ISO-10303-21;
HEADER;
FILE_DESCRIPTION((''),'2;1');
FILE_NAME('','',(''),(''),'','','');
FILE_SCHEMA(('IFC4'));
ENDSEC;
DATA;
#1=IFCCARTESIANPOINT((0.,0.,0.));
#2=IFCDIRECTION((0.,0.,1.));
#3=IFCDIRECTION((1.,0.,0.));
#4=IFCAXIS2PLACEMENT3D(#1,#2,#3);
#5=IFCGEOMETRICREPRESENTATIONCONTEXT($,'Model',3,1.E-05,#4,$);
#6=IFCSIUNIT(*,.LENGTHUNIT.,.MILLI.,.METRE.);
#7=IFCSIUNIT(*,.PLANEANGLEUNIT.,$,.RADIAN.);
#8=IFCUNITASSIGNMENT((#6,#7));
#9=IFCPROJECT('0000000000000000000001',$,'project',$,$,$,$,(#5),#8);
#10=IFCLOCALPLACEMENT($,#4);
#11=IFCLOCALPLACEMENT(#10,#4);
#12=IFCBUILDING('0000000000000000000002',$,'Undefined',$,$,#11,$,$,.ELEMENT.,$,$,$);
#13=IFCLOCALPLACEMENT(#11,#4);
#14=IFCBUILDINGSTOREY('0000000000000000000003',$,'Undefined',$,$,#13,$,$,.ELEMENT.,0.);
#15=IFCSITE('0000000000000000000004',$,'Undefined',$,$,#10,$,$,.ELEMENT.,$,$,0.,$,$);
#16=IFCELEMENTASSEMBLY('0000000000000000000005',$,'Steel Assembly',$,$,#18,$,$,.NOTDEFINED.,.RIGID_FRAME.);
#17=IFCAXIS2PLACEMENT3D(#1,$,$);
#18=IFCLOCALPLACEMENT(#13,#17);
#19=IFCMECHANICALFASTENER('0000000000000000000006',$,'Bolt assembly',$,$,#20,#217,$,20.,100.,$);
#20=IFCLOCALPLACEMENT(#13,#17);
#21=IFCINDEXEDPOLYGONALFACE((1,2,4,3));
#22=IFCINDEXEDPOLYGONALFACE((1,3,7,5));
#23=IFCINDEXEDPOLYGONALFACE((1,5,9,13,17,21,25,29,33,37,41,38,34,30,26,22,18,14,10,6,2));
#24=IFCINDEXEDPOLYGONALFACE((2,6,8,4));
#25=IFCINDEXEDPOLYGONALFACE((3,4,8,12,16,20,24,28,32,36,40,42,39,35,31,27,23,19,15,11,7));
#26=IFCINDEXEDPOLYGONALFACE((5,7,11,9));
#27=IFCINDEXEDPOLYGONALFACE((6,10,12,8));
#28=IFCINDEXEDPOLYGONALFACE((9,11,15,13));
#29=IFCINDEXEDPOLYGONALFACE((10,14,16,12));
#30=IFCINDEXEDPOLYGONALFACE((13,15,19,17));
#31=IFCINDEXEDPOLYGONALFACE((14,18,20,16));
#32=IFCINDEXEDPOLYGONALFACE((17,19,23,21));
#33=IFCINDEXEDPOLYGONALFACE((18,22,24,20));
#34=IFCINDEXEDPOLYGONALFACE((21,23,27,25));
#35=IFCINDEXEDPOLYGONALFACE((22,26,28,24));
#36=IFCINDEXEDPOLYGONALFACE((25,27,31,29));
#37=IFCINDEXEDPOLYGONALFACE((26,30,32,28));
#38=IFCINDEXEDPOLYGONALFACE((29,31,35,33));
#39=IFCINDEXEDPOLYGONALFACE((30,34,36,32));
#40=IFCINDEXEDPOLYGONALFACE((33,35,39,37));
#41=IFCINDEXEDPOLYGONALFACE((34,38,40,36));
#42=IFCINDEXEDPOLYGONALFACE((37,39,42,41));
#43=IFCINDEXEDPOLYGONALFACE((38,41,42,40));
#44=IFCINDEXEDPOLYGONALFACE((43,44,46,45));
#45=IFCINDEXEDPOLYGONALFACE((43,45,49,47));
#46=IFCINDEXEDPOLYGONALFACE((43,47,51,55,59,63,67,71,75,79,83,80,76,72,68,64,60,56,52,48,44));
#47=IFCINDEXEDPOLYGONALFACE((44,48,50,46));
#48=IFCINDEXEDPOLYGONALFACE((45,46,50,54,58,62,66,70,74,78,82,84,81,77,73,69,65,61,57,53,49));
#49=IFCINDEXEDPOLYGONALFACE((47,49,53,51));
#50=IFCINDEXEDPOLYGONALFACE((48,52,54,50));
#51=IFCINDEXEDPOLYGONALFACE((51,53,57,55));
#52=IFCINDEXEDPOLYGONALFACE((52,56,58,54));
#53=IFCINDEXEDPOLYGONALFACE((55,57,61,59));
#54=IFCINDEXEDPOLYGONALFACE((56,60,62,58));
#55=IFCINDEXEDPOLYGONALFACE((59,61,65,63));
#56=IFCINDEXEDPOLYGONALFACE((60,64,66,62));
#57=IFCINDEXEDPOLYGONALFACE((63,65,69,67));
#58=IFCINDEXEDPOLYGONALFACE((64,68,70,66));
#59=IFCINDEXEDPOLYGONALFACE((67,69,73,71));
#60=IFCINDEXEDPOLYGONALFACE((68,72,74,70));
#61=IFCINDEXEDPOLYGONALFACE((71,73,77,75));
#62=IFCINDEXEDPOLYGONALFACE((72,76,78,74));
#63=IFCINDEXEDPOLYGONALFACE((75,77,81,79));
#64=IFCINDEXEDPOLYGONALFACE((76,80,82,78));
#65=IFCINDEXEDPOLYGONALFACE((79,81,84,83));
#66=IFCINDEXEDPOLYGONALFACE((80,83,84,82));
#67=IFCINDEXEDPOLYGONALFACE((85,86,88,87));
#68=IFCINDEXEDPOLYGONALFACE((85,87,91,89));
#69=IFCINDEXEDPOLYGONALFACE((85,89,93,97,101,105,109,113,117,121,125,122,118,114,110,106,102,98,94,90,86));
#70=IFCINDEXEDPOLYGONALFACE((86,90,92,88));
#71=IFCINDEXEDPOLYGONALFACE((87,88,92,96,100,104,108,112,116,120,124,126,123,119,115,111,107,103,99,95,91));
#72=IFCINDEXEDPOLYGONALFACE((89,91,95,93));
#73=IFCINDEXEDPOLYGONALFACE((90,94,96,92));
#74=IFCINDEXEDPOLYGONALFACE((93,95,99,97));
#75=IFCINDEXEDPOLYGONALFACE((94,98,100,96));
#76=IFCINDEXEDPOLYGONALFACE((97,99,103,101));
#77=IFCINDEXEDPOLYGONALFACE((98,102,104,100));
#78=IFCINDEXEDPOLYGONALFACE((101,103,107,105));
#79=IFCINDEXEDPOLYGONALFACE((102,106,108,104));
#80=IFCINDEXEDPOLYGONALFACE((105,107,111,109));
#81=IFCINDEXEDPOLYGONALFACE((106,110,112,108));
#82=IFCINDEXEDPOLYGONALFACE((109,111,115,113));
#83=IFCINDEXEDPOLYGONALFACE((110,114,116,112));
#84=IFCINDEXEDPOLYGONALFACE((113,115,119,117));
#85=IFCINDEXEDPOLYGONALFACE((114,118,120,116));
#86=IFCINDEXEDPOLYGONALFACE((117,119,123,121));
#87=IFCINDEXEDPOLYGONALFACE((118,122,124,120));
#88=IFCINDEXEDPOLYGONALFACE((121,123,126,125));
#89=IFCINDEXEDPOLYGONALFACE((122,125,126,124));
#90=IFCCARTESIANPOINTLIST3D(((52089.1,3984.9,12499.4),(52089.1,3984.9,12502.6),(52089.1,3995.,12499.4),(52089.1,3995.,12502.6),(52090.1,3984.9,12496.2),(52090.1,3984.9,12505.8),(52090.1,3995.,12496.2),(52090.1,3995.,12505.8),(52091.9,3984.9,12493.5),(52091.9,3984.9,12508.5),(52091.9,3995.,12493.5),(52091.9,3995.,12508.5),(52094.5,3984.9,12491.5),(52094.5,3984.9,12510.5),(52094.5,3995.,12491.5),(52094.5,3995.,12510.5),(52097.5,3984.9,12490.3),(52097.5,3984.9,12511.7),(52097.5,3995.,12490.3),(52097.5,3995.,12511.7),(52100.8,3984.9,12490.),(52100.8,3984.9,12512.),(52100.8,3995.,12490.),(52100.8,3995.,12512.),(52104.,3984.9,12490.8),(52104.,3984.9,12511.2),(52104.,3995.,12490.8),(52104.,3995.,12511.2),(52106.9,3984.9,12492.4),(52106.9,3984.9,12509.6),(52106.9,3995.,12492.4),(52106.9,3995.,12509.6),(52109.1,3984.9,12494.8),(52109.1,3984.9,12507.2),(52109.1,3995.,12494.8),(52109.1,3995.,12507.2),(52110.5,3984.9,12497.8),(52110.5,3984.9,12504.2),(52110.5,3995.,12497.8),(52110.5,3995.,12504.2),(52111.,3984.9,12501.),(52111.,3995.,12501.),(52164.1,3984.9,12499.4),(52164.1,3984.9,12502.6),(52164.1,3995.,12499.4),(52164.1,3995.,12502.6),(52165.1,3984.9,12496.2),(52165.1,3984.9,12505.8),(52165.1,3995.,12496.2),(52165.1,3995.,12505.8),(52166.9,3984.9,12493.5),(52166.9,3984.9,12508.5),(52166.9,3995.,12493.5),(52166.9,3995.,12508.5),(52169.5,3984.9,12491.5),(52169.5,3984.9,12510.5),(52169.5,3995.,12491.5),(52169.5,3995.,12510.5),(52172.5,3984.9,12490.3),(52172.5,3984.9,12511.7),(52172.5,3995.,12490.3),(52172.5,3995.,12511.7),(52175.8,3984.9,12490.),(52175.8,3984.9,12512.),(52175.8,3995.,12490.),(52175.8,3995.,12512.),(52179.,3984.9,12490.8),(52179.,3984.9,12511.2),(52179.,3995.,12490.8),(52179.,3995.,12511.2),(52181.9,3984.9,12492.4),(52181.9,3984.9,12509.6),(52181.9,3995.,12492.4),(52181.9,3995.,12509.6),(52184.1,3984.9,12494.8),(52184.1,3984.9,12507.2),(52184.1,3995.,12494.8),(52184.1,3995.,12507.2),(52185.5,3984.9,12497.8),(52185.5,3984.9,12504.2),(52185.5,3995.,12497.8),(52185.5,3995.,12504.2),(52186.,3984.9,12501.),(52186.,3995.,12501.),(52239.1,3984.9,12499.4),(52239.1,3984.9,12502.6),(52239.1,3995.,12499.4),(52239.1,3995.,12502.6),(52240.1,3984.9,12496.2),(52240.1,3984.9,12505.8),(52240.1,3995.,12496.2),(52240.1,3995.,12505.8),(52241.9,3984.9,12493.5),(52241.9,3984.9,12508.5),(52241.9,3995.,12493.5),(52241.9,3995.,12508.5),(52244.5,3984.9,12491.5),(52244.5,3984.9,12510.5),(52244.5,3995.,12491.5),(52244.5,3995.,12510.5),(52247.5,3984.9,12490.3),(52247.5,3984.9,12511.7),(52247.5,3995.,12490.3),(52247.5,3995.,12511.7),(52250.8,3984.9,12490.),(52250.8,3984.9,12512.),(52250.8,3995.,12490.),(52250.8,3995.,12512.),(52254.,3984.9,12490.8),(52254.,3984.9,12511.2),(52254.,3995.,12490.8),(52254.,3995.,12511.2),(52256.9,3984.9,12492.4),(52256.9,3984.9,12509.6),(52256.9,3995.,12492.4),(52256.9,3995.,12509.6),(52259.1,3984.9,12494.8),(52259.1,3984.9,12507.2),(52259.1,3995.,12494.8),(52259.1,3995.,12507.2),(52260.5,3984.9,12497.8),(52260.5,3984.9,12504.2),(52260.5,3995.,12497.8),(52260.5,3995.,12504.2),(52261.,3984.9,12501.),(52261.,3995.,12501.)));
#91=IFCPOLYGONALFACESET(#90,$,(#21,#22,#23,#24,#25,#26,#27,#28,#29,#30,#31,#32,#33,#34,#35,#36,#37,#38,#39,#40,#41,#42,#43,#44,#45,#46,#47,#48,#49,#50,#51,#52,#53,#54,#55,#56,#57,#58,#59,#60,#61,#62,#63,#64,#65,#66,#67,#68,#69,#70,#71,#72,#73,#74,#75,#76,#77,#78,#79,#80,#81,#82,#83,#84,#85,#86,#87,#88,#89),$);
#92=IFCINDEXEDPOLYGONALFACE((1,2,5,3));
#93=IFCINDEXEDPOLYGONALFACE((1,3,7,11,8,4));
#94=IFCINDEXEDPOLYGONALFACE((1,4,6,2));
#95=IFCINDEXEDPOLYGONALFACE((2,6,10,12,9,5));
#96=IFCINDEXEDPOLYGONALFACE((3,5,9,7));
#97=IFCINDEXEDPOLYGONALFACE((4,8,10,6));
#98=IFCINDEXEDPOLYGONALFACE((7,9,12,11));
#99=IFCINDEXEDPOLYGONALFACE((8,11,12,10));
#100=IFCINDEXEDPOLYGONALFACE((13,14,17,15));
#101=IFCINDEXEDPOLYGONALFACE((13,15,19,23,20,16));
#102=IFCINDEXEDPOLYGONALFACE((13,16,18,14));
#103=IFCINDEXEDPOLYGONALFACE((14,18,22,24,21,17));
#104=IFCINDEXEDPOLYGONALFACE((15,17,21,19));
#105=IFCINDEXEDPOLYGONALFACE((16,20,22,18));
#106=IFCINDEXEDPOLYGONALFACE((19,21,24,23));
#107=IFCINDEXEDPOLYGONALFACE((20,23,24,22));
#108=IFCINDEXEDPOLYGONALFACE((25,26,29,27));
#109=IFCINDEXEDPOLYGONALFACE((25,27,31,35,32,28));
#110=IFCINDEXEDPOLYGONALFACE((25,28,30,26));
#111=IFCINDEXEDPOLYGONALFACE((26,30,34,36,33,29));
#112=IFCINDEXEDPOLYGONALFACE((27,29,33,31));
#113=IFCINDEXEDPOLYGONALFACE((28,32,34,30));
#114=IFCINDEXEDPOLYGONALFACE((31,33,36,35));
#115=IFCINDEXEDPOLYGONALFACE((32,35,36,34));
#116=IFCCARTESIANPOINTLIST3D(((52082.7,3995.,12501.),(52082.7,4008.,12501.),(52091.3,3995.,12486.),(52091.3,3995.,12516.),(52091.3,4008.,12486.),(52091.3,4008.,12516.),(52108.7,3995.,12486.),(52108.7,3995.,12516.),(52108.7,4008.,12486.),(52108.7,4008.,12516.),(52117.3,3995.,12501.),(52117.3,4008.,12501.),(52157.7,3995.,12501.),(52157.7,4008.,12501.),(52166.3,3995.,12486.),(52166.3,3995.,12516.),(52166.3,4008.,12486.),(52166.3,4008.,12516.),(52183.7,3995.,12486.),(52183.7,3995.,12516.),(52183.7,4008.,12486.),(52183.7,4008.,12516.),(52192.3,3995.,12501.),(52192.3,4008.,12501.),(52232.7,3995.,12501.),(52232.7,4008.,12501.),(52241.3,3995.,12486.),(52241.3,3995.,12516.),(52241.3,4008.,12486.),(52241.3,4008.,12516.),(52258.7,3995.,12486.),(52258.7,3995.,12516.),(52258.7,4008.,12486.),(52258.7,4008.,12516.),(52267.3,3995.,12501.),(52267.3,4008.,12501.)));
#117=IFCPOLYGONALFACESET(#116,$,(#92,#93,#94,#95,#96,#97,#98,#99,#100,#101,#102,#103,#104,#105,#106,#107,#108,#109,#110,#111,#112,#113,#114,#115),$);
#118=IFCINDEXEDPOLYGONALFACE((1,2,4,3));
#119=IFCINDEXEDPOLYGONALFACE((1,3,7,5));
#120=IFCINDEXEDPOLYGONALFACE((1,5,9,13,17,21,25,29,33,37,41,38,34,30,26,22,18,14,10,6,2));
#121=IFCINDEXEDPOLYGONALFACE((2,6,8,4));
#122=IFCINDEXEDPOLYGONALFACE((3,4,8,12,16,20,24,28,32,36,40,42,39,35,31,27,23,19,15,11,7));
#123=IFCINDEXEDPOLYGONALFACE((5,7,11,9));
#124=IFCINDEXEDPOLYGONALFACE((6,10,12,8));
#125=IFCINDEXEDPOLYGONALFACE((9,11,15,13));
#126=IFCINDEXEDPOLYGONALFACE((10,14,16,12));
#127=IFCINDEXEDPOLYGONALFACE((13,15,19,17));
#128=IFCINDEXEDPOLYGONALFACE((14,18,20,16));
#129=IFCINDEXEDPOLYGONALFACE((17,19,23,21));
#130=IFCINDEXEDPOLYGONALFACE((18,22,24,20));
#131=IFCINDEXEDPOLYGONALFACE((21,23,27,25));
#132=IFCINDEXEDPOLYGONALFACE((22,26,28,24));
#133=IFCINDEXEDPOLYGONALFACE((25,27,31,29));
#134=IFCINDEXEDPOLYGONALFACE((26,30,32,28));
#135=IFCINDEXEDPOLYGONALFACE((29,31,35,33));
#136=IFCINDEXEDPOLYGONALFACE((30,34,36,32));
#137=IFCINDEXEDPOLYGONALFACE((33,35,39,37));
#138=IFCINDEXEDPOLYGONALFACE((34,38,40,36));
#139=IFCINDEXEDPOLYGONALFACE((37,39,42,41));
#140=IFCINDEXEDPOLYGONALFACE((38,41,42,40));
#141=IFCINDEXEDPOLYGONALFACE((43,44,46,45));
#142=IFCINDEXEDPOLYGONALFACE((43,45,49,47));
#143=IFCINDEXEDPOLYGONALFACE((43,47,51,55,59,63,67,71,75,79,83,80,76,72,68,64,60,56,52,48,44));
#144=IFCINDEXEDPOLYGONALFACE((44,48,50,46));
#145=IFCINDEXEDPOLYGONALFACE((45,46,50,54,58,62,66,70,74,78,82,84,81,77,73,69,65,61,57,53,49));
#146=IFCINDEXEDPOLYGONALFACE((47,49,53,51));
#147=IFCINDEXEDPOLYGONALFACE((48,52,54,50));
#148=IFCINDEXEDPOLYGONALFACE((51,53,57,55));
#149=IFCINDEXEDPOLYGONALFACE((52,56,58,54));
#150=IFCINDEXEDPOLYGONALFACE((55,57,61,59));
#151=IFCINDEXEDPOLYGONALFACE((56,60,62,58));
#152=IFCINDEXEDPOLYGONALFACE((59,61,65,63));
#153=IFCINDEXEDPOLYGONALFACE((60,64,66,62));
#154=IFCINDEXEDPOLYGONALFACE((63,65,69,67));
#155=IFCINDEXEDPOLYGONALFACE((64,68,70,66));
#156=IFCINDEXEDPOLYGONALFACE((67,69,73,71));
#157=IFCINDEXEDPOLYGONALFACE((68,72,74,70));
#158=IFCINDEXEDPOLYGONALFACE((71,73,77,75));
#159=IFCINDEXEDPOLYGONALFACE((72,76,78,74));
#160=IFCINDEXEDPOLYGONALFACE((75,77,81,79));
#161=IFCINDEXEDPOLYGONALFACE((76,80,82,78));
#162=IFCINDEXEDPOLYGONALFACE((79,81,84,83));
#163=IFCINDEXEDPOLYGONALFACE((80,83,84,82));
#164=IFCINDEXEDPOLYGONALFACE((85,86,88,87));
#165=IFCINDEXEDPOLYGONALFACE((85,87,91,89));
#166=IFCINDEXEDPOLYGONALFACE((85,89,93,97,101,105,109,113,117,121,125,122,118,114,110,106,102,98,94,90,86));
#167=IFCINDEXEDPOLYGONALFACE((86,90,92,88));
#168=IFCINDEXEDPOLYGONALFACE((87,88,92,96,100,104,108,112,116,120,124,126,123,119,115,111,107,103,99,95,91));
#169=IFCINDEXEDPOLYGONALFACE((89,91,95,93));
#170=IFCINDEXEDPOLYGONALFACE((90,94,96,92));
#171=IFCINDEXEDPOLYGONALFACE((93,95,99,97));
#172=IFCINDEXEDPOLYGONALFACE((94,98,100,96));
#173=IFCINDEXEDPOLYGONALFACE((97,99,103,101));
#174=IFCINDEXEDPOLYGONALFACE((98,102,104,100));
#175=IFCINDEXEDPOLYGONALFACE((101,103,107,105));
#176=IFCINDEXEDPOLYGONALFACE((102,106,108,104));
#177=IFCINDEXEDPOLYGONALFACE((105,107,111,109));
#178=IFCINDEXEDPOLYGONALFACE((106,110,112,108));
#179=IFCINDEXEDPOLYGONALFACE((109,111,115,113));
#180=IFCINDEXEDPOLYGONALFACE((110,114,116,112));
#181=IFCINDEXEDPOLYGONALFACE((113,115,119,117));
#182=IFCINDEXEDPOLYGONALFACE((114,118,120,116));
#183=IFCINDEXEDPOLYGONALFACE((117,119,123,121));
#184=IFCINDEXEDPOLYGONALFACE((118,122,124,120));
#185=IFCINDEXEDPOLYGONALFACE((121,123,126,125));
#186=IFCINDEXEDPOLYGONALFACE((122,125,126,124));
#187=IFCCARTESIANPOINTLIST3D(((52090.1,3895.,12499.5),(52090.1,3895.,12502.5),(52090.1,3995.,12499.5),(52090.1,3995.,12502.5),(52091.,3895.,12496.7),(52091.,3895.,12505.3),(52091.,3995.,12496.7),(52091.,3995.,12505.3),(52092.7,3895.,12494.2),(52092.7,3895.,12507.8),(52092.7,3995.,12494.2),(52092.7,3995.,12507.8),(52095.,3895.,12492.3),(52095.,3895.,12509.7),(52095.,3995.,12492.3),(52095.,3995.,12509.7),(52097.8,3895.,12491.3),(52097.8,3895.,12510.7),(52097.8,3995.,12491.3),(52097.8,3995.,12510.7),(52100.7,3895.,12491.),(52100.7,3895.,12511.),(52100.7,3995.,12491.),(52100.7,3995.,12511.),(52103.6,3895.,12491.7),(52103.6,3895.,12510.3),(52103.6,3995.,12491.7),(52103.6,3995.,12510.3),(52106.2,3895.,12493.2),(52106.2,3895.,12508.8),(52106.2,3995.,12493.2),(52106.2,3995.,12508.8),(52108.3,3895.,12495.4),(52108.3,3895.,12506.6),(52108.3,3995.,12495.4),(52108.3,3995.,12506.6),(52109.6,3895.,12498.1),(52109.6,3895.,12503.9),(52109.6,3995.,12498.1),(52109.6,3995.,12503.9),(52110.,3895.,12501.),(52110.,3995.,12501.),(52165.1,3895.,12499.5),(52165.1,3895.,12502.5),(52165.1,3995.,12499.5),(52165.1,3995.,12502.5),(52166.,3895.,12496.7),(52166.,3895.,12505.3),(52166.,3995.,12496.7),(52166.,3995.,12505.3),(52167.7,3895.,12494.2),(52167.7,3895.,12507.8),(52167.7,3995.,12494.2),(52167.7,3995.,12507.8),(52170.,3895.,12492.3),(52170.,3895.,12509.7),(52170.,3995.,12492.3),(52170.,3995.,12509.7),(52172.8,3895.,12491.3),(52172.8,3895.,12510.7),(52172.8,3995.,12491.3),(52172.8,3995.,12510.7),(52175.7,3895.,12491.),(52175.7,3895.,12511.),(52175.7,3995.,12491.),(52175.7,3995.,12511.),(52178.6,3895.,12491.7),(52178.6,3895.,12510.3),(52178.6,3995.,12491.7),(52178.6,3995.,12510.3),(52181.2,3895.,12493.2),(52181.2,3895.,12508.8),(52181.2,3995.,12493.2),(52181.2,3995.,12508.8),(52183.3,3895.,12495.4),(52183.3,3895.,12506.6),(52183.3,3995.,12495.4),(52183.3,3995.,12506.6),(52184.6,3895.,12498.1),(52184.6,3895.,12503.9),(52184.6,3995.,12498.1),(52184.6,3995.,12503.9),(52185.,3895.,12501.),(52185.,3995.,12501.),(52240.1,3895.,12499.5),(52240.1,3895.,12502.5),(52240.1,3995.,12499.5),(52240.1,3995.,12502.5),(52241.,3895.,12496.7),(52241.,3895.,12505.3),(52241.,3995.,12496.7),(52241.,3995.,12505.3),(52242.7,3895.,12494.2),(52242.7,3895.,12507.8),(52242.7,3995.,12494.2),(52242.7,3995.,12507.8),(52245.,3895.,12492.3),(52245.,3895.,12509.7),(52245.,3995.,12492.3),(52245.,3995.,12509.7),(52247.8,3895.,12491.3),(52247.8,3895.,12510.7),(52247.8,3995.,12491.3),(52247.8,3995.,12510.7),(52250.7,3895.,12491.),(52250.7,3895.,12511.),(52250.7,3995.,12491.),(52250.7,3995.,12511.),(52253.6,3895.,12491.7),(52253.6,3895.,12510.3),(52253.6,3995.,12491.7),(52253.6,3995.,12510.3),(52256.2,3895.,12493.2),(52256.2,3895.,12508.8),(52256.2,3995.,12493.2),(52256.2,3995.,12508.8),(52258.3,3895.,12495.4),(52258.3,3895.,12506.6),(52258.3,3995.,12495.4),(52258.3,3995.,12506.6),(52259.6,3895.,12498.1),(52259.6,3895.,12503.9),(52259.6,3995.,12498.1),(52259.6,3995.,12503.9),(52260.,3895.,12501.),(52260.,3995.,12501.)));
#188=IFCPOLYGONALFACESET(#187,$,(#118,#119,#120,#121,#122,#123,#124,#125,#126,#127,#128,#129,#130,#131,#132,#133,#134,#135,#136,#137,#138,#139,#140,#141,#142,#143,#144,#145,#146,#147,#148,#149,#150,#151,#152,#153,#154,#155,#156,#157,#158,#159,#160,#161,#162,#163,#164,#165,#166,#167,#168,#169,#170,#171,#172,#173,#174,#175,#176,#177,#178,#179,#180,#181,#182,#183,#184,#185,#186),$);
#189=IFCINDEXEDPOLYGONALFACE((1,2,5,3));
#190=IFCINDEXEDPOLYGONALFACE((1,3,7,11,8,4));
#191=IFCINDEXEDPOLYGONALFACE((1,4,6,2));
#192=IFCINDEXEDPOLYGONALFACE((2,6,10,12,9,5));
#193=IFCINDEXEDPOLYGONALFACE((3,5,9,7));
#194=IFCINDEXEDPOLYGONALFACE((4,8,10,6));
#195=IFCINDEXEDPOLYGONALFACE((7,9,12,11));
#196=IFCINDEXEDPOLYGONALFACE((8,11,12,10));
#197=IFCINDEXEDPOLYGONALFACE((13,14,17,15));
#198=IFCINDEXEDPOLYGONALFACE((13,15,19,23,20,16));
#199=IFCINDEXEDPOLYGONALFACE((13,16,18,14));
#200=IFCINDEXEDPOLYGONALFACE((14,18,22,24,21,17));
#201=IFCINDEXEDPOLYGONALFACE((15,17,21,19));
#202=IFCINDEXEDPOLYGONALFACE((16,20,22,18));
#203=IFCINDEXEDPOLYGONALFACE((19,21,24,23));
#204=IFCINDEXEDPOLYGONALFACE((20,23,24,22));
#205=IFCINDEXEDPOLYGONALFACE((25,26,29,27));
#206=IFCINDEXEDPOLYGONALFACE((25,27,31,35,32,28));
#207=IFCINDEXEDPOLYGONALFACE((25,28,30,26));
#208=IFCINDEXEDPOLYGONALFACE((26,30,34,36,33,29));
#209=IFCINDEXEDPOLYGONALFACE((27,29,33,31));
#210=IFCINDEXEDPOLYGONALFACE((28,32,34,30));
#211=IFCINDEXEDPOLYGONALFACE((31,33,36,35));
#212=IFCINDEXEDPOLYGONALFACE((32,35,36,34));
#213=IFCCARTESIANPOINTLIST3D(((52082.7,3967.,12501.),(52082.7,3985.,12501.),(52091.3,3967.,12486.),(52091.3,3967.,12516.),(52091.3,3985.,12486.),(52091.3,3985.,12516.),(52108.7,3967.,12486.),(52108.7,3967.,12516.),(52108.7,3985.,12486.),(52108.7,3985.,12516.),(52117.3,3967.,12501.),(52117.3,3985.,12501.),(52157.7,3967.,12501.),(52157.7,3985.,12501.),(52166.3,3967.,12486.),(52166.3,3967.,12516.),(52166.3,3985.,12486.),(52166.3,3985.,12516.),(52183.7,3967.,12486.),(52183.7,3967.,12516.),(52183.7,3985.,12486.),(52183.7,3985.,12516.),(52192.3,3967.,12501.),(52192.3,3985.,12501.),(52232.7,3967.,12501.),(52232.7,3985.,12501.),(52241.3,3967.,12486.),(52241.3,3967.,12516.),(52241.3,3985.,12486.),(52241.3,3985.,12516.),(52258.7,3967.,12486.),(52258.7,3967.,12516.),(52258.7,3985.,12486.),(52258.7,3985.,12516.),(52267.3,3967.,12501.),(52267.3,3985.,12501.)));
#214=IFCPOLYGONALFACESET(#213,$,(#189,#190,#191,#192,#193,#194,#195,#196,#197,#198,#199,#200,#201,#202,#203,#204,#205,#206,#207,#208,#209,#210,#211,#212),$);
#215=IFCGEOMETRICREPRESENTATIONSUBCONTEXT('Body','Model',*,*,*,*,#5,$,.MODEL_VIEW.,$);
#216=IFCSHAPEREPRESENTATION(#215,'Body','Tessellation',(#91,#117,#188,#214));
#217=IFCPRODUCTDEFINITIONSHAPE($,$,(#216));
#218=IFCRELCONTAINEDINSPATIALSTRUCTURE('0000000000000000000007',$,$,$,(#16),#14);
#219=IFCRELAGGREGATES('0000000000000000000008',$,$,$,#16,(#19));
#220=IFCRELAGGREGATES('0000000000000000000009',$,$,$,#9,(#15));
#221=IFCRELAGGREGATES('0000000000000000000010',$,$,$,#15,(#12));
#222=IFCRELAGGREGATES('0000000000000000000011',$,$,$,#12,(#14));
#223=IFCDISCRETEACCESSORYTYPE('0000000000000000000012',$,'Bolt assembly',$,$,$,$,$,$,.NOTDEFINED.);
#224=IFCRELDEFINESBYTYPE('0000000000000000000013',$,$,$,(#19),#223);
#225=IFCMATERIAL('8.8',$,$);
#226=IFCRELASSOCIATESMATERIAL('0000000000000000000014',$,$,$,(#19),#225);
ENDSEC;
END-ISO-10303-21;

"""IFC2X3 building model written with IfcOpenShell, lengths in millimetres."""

from ifc_helpers import new_model, si_unit, frame, origin_with_axes, origin_2d_with_axis, place, context, subcontext, project, spatial, polyline, circle, outline, extrude, source, transform, mapped, material, type_object, element, aggregate, save


model = new_model("IFC2X3")

# Units and contexts
model_context = context("Model", 3, precision=1e-05, world=origin_with_axes())
body_context = subcontext(model_context, "Body", "Model", "MODEL_VIEW")
ifc_project = project(units=[si_unit("LENGTHUNIT", "METRE", prefix="MILLI"), si_unit("PLANEANGLEUNIT", "RADIAN")], contexts=[model_context])

# Site, building, storey
site_placement = place(None, origin_with_axes())
site = spatial("IfcSite", under=ifc_project, at=site_placement, Name="Undefined", CompositionType="ELEMENT", RefElevation=0.0)
building_placement = place(site_placement, origin_with_axes())
building = spatial("IfcBuilding", under=site, at=building_placement, Name="Undefined", CompositionType="ELEMENT")
storey_placement = place(building_placement, origin_with_axes())
storey = spatial("IfcBuildingStorey", under=building, at=storey_placement, Name="Undefined", CompositionType="ELEMENT", Elevation=0.0)

# Element assembly
assembly_1_placement = place(storey_placement, origin_with_axes())
assembly_1 = element("IfcElementAssembly", 1, at=assembly_1_placement, inside=storey, Name="Steel Assembly", AssemblyPlace="NOTDEFINED", PredefinedType="RIGID_FRAME")

# Shared definitions
ifc_material_1 = material(Name="8.8")
discrete_accessory_type_1 = type_object("IfcDiscreteAccessoryType", Name="Bolt assembly")

# Mechanical fastener
shared_shape_1 = source(origin_with_axes(), body_context, "Body", "SweptSolid", [
    extrude(circle(Radius=11.0, at=origin_2d_with_axis()), frame((0.0, 5.0, 0.0), z_axis=(0.0, 1.0, 0.0), x_axis=(1.0, 0.0, 0.0)), (0.0, 0.0, 1.0), 10.1),
    extrude(outline(polyline([(17.3, 0.0), (8.7, 15.0), (-8.7, 15.0), (-17.3, 0.0), (-8.7, -15.0), (8.7, -15.0), (17.3, 0.0)])), frame((0.0, -8.0, 0.0), z_axis=(0.0, 1.0, 0.0), x_axis=(1.0, 0.0, 0.0)), (0.0, 0.0, 1.0), 13.0),
    extrude(circle(Radius=10.0, at=origin_2d_with_axis()), frame((0.0, 5.0, 0.0), z_axis=(0.0, 1.0, 0.0), x_axis=(1.0, 0.0, 0.0)), (0.0, 0.0, 1.0), 100.0),
    extrude(outline(polyline([(17.3, 0.0), (8.7, 15.0), (-8.7, 15.0), (-17.3, 0.0), (-8.7, -15.0), (8.7, -15.0), (17.3, 0.0)])), frame((0.0, 15.0, 0.0), z_axis=(0.0, 1.0, 0.0), x_axis=(1.0, 0.0, 0.0)), (0.0, 0.0, 1.0), 18.0),
])
mechanical_fastener_1_placement = place(assembly_1_placement, frame((52100.0, 4000.0, 12501.0), z_axis=(0.0, 0.0, -1.0), x_axis=(1.0, 0.0, 0.0)))
mechanical_fastener_1 = element("IfcMechanicalFastener", 2, at=mechanical_fastener_1_placement, type_object=discrete_accessory_type_1, material=ifc_material_1, Name="Bolt assembly", NominalDiameter=20.0, NominalLength=100.0, context=body_context, shape_type="MappedRepresentation", body=[
    mapped(shared_shape_1, transform((0.0, 0.0, 0.0))),
    mapped(shared_shape_1, transform((75.0, 0.0, 0.0))),
    mapped(shared_shape_1, transform((150.0, 0.0, 0.0))),
])
aggregate(assembly_1, [mechanical_fastener_1])

save(model, "model.ifc")
